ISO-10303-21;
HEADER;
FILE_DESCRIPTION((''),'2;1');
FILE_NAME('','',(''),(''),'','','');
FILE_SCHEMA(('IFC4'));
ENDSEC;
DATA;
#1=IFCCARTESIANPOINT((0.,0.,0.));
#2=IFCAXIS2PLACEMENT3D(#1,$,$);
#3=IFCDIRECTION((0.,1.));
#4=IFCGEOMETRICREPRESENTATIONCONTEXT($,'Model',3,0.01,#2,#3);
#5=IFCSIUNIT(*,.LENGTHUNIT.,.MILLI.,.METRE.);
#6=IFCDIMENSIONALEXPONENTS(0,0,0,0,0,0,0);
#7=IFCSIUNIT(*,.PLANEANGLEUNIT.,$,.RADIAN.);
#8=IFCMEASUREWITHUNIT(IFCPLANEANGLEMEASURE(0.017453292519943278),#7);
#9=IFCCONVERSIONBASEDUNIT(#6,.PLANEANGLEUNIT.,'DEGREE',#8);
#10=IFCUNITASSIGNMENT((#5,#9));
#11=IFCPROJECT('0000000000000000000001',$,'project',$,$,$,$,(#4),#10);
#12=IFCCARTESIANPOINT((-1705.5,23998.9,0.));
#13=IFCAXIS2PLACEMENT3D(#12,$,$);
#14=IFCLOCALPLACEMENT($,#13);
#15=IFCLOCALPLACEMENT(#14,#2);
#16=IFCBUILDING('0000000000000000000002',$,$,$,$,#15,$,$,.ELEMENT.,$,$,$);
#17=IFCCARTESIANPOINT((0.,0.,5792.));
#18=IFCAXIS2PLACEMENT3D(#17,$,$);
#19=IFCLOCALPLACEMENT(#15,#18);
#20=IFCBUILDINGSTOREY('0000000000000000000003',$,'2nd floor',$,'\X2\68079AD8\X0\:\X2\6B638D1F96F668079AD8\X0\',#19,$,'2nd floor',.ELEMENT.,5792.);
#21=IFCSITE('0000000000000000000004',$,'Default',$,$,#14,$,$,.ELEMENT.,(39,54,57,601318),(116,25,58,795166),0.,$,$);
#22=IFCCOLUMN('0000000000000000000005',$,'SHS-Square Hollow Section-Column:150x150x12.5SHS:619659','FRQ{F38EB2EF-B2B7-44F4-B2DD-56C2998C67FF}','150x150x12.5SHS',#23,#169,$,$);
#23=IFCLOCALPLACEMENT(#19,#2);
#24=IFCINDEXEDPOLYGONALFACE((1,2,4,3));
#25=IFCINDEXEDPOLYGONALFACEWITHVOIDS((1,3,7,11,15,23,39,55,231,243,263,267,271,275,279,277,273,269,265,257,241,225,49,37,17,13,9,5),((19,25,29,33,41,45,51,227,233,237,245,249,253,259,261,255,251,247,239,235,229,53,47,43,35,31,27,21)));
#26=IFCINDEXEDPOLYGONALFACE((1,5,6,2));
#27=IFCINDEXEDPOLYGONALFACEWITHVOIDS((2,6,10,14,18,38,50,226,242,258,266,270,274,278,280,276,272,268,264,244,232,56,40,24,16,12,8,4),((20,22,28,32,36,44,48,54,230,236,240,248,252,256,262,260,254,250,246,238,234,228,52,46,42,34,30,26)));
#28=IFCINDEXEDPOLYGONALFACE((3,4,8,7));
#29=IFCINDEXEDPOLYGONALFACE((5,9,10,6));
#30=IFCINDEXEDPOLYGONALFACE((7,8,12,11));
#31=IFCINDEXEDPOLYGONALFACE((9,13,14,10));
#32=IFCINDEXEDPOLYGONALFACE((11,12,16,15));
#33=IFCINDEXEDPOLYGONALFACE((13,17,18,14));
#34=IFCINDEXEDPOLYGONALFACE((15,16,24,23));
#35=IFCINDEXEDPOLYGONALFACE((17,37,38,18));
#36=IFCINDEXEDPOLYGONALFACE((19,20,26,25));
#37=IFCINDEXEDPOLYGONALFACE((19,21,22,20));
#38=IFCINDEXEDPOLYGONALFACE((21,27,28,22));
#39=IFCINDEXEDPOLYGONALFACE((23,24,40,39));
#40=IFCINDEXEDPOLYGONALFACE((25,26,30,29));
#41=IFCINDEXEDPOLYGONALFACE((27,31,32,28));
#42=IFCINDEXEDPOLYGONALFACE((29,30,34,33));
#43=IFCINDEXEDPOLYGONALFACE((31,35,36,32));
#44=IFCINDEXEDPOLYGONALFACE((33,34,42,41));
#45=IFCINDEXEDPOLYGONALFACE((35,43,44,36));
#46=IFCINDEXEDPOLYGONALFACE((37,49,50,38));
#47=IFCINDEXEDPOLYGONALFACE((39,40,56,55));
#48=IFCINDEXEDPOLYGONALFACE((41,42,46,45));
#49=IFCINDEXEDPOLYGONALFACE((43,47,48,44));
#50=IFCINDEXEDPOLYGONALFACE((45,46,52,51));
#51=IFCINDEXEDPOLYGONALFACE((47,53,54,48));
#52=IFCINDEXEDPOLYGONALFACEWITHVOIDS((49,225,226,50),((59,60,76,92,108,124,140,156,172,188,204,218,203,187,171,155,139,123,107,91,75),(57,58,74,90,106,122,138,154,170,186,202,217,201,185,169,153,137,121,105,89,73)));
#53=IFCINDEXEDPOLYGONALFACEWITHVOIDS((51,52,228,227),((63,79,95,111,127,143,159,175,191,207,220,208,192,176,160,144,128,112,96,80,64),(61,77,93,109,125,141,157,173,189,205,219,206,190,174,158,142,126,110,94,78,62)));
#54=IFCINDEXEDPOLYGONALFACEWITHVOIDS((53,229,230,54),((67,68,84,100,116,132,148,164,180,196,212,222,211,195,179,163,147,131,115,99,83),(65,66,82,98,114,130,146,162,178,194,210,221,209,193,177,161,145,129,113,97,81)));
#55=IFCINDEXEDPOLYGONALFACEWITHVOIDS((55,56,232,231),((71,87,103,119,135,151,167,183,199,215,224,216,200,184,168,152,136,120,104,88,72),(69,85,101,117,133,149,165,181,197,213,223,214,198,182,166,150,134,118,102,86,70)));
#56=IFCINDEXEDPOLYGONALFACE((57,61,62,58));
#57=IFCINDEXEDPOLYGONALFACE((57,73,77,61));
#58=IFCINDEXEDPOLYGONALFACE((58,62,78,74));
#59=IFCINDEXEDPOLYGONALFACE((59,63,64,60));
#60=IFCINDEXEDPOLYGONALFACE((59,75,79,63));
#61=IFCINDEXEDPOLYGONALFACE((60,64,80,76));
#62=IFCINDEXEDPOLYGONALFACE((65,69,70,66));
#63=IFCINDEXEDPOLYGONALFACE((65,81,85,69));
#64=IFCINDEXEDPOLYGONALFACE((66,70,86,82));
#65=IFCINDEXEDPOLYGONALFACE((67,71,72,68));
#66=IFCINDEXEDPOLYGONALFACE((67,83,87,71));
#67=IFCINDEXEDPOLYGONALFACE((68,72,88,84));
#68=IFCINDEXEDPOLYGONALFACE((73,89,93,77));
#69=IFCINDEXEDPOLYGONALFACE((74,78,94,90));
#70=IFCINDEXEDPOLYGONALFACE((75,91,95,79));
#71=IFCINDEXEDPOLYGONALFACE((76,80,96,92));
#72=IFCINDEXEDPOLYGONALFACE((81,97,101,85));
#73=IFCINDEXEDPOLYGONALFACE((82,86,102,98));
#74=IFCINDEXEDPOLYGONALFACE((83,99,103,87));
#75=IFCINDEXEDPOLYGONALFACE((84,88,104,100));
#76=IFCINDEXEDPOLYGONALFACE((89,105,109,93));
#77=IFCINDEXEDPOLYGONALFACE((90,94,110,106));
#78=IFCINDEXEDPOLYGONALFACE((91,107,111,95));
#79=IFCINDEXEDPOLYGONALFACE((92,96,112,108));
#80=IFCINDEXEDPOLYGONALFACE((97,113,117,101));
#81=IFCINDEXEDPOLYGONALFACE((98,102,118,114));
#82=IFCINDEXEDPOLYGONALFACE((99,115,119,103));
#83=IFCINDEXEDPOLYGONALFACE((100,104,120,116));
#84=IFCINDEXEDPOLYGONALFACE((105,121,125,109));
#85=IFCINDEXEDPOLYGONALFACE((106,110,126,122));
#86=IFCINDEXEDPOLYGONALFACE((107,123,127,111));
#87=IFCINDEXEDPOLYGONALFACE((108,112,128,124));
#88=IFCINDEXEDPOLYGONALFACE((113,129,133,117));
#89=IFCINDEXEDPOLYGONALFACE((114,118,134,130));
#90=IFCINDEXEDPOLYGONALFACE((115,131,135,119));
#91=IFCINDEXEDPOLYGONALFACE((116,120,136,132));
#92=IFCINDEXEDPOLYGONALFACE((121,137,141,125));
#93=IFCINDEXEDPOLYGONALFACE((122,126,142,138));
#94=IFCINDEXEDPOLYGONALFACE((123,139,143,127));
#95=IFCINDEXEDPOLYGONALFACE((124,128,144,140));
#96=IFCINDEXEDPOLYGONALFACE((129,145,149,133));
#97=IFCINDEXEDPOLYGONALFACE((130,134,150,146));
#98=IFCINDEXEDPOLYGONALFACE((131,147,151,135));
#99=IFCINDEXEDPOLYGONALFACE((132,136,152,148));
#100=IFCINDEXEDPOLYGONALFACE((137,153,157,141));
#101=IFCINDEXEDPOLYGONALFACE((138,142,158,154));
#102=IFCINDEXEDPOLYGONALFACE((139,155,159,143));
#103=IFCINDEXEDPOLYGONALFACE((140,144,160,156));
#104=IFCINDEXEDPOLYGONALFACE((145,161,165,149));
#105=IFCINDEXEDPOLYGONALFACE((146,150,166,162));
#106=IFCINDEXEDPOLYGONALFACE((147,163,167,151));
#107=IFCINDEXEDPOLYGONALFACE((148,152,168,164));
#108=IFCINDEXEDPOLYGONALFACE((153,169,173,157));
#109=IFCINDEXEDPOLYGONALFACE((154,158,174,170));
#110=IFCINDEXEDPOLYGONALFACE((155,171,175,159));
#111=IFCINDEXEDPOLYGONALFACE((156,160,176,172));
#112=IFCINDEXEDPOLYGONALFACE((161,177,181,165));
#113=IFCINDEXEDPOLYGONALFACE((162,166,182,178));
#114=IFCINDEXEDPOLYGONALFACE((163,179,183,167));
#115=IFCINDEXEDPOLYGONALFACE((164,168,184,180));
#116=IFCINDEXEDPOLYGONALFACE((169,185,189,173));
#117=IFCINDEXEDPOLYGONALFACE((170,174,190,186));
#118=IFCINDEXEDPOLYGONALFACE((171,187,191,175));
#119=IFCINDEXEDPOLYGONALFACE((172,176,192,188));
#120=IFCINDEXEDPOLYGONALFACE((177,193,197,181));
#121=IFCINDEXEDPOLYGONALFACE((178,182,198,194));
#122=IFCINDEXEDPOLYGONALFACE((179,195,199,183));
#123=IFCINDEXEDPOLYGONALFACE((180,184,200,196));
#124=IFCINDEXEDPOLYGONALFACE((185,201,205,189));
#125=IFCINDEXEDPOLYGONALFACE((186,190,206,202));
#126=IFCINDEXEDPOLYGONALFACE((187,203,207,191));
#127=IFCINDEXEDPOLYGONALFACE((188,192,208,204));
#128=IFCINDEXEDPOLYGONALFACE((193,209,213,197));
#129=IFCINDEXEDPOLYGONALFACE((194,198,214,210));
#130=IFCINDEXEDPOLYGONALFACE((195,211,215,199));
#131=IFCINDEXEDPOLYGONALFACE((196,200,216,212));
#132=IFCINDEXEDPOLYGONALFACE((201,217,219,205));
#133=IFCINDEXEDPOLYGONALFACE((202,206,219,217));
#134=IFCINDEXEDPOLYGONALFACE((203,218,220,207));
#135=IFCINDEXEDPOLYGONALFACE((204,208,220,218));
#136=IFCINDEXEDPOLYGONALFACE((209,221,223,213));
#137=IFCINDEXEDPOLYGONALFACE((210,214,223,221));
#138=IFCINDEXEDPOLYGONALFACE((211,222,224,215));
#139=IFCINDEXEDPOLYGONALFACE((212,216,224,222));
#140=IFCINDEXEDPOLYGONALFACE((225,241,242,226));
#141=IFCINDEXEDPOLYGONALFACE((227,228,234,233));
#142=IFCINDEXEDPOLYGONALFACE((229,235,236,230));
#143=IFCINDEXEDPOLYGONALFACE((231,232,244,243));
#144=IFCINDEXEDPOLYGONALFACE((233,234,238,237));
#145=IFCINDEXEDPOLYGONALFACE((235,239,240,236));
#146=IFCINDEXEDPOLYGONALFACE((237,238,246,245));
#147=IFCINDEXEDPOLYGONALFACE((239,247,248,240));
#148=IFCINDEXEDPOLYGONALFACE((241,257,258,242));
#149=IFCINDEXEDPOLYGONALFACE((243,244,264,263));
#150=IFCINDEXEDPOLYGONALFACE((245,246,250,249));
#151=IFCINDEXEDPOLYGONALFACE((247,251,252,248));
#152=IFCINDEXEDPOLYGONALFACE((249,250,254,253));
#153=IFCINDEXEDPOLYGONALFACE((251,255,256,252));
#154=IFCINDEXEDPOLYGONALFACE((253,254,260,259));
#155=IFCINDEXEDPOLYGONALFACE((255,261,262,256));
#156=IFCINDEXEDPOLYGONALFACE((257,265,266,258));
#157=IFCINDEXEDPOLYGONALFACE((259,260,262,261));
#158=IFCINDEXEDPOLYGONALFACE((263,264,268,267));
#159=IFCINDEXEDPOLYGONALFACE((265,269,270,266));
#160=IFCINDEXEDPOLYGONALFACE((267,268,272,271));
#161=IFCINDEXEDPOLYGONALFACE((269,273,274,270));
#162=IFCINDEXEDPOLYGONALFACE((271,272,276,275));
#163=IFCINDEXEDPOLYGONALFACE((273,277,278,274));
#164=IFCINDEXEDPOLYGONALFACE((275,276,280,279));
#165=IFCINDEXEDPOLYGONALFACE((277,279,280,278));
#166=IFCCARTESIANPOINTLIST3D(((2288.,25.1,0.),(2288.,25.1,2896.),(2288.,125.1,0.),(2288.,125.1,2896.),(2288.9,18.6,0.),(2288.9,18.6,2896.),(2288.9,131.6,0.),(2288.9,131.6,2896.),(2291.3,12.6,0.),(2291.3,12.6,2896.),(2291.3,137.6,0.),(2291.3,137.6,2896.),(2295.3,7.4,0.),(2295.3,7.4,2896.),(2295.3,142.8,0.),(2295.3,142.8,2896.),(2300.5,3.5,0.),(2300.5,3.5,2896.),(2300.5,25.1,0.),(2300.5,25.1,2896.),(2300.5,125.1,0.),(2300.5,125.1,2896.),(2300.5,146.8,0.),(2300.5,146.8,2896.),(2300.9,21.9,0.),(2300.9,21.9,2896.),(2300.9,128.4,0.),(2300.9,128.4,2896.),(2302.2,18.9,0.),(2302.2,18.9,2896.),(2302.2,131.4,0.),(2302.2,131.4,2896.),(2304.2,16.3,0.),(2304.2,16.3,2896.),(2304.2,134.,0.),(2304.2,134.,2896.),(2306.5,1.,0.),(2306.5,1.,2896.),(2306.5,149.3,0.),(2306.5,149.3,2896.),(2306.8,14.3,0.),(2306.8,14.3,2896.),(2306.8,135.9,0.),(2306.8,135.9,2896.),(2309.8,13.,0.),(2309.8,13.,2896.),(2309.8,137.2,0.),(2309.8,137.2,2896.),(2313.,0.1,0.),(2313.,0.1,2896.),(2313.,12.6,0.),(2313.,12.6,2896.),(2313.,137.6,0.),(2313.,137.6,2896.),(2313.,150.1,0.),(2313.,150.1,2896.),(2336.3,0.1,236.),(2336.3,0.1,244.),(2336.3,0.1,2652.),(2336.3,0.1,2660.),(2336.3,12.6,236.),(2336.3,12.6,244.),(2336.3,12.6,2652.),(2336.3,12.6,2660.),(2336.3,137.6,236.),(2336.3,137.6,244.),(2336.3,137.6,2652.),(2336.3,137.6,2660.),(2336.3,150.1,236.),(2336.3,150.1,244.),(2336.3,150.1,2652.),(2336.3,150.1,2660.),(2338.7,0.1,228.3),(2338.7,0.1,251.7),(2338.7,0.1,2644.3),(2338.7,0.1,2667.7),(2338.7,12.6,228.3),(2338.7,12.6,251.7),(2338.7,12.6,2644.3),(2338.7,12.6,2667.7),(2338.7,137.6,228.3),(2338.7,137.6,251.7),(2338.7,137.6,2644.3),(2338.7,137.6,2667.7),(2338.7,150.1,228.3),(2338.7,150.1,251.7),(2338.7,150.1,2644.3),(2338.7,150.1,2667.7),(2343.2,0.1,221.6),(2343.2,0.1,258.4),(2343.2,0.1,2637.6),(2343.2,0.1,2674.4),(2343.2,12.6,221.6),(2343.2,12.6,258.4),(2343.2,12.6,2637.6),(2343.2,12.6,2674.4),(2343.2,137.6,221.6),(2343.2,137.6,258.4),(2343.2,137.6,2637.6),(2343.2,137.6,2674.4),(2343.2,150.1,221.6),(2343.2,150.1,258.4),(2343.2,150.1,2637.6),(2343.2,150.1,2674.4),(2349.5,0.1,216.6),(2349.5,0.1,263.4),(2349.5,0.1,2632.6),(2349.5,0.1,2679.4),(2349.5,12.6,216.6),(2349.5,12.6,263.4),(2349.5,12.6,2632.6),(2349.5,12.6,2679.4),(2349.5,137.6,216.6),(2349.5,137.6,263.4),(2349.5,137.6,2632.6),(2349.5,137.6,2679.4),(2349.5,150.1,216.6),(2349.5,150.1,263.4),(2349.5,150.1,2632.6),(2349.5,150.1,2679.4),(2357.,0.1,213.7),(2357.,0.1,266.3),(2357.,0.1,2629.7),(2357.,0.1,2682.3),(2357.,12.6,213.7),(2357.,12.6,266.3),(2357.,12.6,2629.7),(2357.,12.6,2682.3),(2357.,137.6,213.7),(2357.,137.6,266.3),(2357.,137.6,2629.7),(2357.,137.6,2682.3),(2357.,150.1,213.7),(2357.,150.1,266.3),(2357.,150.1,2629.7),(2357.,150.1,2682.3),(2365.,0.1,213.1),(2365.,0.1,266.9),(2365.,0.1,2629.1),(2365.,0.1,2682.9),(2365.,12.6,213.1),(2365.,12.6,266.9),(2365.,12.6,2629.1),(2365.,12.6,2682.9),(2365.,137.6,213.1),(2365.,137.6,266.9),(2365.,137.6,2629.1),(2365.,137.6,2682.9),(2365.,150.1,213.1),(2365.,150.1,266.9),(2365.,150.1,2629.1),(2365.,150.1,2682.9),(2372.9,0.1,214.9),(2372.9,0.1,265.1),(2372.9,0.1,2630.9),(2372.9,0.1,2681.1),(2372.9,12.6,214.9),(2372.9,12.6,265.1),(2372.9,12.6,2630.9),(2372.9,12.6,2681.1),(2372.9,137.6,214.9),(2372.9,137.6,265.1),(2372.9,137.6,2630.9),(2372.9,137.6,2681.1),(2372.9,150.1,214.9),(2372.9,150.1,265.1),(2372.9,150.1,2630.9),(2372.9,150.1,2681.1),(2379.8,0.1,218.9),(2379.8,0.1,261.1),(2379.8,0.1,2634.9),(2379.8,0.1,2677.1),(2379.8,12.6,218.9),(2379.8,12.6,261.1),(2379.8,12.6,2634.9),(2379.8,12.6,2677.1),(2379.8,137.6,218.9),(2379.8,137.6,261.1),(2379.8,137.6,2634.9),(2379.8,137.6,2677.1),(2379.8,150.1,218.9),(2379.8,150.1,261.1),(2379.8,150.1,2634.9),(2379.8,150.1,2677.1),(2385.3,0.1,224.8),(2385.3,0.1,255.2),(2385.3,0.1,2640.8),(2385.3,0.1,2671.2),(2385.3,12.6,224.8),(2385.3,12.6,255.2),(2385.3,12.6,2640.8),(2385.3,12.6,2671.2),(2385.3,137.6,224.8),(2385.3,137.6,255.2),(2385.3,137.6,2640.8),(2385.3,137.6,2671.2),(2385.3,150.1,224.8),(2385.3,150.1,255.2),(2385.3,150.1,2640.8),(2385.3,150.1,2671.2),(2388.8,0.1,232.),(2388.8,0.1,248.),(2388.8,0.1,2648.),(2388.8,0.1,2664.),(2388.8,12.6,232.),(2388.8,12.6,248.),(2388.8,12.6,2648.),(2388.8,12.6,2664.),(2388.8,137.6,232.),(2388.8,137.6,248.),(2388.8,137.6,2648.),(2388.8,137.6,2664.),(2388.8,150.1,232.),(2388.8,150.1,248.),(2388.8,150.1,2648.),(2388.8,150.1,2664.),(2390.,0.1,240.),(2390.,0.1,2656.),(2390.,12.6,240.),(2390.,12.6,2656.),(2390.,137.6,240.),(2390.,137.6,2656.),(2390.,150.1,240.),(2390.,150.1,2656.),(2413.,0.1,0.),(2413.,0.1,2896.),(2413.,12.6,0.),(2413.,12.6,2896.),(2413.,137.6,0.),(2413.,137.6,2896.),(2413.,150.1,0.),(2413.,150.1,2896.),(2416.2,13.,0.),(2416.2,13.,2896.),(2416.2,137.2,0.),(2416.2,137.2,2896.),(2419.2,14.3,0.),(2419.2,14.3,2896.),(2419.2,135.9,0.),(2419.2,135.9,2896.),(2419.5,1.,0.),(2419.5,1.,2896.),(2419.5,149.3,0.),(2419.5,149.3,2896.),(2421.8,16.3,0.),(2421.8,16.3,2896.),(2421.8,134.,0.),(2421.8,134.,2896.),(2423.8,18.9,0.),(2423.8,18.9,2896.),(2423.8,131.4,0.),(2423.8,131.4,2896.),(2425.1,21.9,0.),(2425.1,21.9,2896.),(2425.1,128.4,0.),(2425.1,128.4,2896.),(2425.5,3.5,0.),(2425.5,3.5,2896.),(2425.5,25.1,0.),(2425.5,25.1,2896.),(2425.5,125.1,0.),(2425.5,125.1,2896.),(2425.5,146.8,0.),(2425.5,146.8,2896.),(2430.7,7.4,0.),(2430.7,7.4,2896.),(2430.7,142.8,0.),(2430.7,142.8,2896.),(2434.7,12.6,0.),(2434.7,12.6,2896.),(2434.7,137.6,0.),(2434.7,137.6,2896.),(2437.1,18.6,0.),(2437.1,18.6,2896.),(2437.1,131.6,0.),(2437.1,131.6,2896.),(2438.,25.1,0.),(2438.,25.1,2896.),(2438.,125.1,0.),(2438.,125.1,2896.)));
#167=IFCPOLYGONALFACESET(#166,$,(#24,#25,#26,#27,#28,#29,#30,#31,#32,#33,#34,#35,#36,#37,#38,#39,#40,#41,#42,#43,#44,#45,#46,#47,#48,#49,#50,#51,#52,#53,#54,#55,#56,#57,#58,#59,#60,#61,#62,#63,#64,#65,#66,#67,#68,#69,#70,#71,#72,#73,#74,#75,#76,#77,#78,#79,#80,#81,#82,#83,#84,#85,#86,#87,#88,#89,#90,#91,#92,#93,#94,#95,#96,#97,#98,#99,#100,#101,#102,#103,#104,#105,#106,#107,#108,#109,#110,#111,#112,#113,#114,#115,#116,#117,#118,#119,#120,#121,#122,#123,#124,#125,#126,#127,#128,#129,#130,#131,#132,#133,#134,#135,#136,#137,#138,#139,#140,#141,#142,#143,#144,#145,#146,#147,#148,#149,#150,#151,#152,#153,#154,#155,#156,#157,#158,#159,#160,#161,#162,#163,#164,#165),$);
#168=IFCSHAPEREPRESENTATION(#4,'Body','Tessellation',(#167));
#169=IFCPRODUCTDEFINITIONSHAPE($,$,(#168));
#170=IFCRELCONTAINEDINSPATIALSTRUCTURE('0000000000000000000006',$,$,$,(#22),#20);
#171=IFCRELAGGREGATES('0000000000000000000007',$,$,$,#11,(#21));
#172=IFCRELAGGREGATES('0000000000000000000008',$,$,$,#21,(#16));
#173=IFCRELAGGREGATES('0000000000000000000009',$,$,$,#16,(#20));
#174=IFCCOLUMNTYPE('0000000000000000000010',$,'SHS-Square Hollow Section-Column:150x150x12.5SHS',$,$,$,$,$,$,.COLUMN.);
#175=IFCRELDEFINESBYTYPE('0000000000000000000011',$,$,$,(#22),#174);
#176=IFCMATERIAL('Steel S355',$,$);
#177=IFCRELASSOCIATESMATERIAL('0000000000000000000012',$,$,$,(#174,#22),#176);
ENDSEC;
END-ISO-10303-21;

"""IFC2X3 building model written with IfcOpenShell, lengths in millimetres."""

from ifc_helpers import new_model, entity, si_unit, converted_unit, direction, frame, frame_2d, origin, origin_2d, place, context, project, spatial, circle_curve, hollow_rectangle, outline, extrude, material, type_object, element, save


model = new_model("IFC2X3")

# Units and contexts
model_context = context("Model", 3, precision=0.01, world=origin(), true_north=direction((0.0, 1.0)))
ifc_project = project(units=[si_unit("LENGTHUNIT", "METRE", prefix="MILLI"), converted_unit("PLANEANGLEUNIT", "DEGREE", entity("IfcPlaneAngleMeasure", 0.017453292519943278), si_unit("PLANEANGLEUNIT", "RADIAN"), dimensions=[0, 0, 0, 0, 0, 0, 0])], contexts=[model_context])

# Site, building, storey
site_placement = place(None, frame((-1705.5, 23998.9, 0.0)))
site = spatial("IfcSite", under=ifc_project, at=site_placement, Name="Default", CompositionType="ELEMENT", RefLatitude=(39, 54, 57, 601318), RefLongitude=(116, 25, 58, 795166), RefElevation=0.0)
building_placement = place(site_placement, origin())
building = spatial("IfcBuilding", under=site, at=building_placement, CompositionType="ELEMENT")
storey_placement = place(building_placement, frame((0.0, 0.0, 5792.0)))
storey = spatial("IfcBuildingStorey", under=building, at=storey_placement, Name="2nd floor", ObjectType="标高:正负零标高", LongName="2nd floor", CompositionType="ELEMENT", Elevation=5792.0)

# Column, openings
ifc_material_1 = material(Name="Steel S355")
column_type_1 = type_object("IfcColumnType", Name="SHS-Square Hollow Section-Column:150x150x12.5SHS", PredefinedType="COLUMN", material=ifc_material_1)
column_1_placement = place(storey_placement, frame((2363.0, 75.1, 2896.0), z_axis=(0.0, 0.0, 1.0), x_axis=(0.0, 1.0, 0.0)))
column_1 = element("IfcColumn", 1, at=column_1_placement, inside=storey, type_object=column_type_1, material=ifc_material_1, Name="SHS-Square Hollow Section-Column:150x150x12.5SHS:619659", Description="FRQ{F38EB2EF-B2B7-44F4-B2DD-56C2998C67FF}", ObjectType="150x150x12.5SHS", context=model_context, shape_type="SweptSolid", body=[
    extrude(hollow_rectangle(XDim=150.0, YDim=150.0, WallThickness=12.5, InnerFilletRadius=12.5, OuterFilletRadius=25.0, at=origin_2d()), origin(), (0.0, 0.0, -1.0), 2896.0),
])
opening_1_placement = place(column_1_placement, frame((175.1, 0.0, 0.0), z_axis=(-1.0, 0.0, 0.0), x_axis=(0.0, -1.0, 0.0)))
element("IfcOpeningElement", 2, at=opening_1_placement, cuts=column_1, ObjectType="Opening", context=model_context, shape_type="SweptSolid", body=[
    extrude(outline(circle_curve(frame_2d((0.0, -240.0), x_axis=(1.0, 0.0)), 27.0)), origin(), (0.0, 0.0, 1.0), 350.2),
])
opening_2_placement = place(column_1_placement, frame((175.1, 0.0, -2896.0), z_axis=(-1.0, 0.0, 0.0), x_axis=(0.0, -1.0, 0.0)))
element("IfcOpeningElement", 3, at=opening_2_placement, cuts=column_1, ObjectType="Opening", context=model_context, shape_type="SweptSolid", body=[
    extrude(outline(circle_curve(frame_2d((0.0, 240.0), x_axis=(1.0, 0.0)), 27.0)), origin(), (0.0, 0.0, 1.0), 350.2),
])

save(model, "model.ifc")
